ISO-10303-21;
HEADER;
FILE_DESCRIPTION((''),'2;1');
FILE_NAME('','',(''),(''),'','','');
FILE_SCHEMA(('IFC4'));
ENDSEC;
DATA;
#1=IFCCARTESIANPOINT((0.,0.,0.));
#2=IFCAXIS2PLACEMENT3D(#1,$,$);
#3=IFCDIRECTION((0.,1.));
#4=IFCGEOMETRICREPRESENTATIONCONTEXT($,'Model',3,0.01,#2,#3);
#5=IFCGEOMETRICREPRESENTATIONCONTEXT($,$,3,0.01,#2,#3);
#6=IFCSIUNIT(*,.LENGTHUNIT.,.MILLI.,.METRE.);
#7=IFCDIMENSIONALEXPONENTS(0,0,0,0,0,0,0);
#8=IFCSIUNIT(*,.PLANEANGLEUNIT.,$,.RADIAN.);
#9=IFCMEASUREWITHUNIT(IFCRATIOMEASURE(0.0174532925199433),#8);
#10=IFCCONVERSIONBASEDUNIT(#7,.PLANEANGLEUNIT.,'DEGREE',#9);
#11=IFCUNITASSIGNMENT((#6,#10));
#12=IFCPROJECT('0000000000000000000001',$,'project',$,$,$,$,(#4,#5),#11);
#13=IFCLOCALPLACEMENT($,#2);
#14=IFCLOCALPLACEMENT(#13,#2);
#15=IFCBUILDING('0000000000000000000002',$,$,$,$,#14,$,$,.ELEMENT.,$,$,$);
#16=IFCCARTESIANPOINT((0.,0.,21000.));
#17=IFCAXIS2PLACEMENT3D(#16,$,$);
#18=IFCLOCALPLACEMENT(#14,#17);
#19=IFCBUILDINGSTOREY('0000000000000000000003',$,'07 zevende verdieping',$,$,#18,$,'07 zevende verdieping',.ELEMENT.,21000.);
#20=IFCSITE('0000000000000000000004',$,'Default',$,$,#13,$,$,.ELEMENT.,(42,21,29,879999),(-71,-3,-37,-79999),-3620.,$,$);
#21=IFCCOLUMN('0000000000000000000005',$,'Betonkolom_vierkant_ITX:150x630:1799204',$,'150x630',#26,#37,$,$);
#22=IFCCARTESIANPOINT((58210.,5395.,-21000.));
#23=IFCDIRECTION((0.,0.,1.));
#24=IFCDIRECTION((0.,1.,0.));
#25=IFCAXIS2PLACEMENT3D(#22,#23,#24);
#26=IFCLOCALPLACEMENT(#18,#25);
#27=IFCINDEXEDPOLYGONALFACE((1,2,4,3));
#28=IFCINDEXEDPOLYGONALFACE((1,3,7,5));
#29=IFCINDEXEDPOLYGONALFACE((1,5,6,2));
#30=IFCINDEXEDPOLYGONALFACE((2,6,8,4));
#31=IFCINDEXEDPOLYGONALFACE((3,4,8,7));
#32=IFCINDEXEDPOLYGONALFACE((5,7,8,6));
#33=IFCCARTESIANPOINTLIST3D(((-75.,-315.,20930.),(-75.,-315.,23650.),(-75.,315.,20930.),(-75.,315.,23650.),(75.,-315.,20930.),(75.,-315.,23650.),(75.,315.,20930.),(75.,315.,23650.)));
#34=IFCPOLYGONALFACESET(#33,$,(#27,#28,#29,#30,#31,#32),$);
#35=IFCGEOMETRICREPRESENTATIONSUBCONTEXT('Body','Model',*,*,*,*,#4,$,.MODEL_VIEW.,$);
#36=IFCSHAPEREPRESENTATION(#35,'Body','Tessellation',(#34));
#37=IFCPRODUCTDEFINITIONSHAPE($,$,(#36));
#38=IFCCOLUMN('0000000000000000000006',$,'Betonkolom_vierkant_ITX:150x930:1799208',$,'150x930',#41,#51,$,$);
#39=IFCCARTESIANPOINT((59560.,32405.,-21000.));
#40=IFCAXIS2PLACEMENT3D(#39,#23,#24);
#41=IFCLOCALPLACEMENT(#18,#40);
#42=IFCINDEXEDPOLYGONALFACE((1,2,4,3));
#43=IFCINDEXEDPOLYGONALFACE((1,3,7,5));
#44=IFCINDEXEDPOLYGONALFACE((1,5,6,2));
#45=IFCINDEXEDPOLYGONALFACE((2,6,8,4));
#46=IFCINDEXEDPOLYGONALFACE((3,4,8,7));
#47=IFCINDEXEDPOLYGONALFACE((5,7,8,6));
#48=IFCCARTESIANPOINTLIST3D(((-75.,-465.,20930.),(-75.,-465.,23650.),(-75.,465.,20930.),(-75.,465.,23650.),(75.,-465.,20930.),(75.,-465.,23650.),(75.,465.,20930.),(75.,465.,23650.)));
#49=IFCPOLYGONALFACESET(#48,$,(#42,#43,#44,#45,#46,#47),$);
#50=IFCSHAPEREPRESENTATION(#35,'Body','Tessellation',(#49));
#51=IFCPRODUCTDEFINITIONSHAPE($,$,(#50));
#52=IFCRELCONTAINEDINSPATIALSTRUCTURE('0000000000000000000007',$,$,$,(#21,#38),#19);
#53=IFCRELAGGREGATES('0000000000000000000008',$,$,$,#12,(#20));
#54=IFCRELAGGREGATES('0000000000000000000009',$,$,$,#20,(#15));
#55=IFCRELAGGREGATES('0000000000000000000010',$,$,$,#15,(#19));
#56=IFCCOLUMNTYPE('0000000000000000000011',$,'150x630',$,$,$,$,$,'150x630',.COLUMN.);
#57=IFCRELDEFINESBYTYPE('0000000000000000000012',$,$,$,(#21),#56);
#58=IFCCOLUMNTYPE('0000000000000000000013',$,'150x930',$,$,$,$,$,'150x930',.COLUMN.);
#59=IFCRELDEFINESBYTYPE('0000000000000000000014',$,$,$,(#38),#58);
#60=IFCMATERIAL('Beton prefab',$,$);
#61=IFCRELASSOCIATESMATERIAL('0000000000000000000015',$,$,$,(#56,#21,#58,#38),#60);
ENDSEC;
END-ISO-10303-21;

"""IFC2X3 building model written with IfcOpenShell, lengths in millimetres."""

from ifc_helpers import new_model, entity, si_unit, converted_unit, direction, frame, origin, origin_2d_with_axis, place, context, subcontext, project, spatial, rectangle, extrude, source, transform, mapped, material, type_object, type_shapes, element, save


model = new_model("IFC2X3")

# Units and contexts
model_context = context("Model", 3, precision=0.01, world=origin(), true_north=direction((0.0, 1.0)))
context_of_model = context(None, 3, precision=0.01, world=origin(), true_north=direction((0.0, 1.0)))
body_context = subcontext(model_context, "Body", "Model", "MODEL_VIEW")
ifc_project = project(units=[si_unit("LENGTHUNIT", "METRE", prefix="MILLI"), converted_unit("PLANEANGLEUNIT", "DEGREE", entity("IfcRatioMeasure", 0.0174532925199433), si_unit("PLANEANGLEUNIT", "RADIAN"), dimensions=[0, 0, 0, 0, 0, 0, 0])], contexts=[model_context, context_of_model])

# Site, building, storey
site_placement = place(None, origin())
site = spatial("IfcSite", under=ifc_project, at=site_placement, Name="Default", CompositionType="ELEMENT", RefLatitude=(42, 21, 29, 879999), RefLongitude=(-71, -3, -37, -79999), RefElevation=-3620.0)
building_placement = place(site_placement, origin())
building = spatial("IfcBuilding", under=site, at=building_placement, CompositionType="ELEMENT")
storey_placement = place(building_placement, frame((0.0, 0.0, 21000.0)))
storey = spatial("IfcBuildingStorey", under=building, at=storey_placement, Name="07 zevende verdieping", LongName="07 zevende verdieping", CompositionType="ELEMENT", Elevation=21000.0)

# Columns
ifc_material_1 = material(Name="Beton prefab")
column_type_1 = type_object("IfcColumnType", Name="150x630", ElementType="150x630", PredefinedType="COLUMN", material=ifc_material_1)
shared_shape_1 = source(origin(), body_context, "Body", "SweptSolid", [
    extrude(rectangle(XDim=630.0, YDim=150.0, at=origin_2d_with_axis()), frame((0.0, 0.0, 20930.0), z_axis=(0.0, 0.0, 1.0), x_axis=(0.0, -1.0, 0.0)), (0.0, 0.0, 1.0), 2720.0),
])
type_shapes(column_type_1, [shared_shape_1])
column_1_placement = place(storey_placement, frame((58210.0, 5395.0, -21000.0), z_axis=(0.0, 0.0, 1.0), x_axis=(0.0, 1.0, 0.0)))
element("IfcColumn", 1, at=column_1_placement, inside=storey, type_object=column_type_1, material=ifc_material_1, Name="Betonkolom_vierkant_ITX:150x630:1799204", ObjectType="150x630", context=body_context, shape_type="MappedRepresentation", body=[
    mapped(shared_shape_1, transform((0.0, 0.0, 0.0), scale=1.0)),
])
column_type_2 = type_object("IfcColumnType", Name="150x930", ElementType="150x930", PredefinedType="COLUMN", material=ifc_material_1)
shared_shape_2 = source(origin(), body_context, "Body", "SweptSolid", [
    extrude(rectangle(XDim=930.0, YDim=150.0, at=origin_2d_with_axis()), frame((0.0, 0.0, 20930.0), z_axis=(0.0, 0.0, 1.0), x_axis=(0.0, -1.0, 0.0)), (0.0, 0.0, 1.0), 2720.0),
])
type_shapes(column_type_2, [shared_shape_2])
column_2_placement = place(storey_placement, frame((59560.0, 32405.0, -21000.0), z_axis=(0.0, 0.0, 1.0), x_axis=(0.0, 1.0, 0.0)))
element("IfcColumn", 2, at=column_2_placement, inside=storey, type_object=column_type_2, material=ifc_material_1, Name="Betonkolom_vierkant_ITX:150x930:1799208", ObjectType="150x930", context=body_context, shape_type="MappedRepresentation", body=[
    mapped(shared_shape_2, transform((0.0, 0.0, 0.0), scale=1.0)),
])

save(model, "model.ifc")
